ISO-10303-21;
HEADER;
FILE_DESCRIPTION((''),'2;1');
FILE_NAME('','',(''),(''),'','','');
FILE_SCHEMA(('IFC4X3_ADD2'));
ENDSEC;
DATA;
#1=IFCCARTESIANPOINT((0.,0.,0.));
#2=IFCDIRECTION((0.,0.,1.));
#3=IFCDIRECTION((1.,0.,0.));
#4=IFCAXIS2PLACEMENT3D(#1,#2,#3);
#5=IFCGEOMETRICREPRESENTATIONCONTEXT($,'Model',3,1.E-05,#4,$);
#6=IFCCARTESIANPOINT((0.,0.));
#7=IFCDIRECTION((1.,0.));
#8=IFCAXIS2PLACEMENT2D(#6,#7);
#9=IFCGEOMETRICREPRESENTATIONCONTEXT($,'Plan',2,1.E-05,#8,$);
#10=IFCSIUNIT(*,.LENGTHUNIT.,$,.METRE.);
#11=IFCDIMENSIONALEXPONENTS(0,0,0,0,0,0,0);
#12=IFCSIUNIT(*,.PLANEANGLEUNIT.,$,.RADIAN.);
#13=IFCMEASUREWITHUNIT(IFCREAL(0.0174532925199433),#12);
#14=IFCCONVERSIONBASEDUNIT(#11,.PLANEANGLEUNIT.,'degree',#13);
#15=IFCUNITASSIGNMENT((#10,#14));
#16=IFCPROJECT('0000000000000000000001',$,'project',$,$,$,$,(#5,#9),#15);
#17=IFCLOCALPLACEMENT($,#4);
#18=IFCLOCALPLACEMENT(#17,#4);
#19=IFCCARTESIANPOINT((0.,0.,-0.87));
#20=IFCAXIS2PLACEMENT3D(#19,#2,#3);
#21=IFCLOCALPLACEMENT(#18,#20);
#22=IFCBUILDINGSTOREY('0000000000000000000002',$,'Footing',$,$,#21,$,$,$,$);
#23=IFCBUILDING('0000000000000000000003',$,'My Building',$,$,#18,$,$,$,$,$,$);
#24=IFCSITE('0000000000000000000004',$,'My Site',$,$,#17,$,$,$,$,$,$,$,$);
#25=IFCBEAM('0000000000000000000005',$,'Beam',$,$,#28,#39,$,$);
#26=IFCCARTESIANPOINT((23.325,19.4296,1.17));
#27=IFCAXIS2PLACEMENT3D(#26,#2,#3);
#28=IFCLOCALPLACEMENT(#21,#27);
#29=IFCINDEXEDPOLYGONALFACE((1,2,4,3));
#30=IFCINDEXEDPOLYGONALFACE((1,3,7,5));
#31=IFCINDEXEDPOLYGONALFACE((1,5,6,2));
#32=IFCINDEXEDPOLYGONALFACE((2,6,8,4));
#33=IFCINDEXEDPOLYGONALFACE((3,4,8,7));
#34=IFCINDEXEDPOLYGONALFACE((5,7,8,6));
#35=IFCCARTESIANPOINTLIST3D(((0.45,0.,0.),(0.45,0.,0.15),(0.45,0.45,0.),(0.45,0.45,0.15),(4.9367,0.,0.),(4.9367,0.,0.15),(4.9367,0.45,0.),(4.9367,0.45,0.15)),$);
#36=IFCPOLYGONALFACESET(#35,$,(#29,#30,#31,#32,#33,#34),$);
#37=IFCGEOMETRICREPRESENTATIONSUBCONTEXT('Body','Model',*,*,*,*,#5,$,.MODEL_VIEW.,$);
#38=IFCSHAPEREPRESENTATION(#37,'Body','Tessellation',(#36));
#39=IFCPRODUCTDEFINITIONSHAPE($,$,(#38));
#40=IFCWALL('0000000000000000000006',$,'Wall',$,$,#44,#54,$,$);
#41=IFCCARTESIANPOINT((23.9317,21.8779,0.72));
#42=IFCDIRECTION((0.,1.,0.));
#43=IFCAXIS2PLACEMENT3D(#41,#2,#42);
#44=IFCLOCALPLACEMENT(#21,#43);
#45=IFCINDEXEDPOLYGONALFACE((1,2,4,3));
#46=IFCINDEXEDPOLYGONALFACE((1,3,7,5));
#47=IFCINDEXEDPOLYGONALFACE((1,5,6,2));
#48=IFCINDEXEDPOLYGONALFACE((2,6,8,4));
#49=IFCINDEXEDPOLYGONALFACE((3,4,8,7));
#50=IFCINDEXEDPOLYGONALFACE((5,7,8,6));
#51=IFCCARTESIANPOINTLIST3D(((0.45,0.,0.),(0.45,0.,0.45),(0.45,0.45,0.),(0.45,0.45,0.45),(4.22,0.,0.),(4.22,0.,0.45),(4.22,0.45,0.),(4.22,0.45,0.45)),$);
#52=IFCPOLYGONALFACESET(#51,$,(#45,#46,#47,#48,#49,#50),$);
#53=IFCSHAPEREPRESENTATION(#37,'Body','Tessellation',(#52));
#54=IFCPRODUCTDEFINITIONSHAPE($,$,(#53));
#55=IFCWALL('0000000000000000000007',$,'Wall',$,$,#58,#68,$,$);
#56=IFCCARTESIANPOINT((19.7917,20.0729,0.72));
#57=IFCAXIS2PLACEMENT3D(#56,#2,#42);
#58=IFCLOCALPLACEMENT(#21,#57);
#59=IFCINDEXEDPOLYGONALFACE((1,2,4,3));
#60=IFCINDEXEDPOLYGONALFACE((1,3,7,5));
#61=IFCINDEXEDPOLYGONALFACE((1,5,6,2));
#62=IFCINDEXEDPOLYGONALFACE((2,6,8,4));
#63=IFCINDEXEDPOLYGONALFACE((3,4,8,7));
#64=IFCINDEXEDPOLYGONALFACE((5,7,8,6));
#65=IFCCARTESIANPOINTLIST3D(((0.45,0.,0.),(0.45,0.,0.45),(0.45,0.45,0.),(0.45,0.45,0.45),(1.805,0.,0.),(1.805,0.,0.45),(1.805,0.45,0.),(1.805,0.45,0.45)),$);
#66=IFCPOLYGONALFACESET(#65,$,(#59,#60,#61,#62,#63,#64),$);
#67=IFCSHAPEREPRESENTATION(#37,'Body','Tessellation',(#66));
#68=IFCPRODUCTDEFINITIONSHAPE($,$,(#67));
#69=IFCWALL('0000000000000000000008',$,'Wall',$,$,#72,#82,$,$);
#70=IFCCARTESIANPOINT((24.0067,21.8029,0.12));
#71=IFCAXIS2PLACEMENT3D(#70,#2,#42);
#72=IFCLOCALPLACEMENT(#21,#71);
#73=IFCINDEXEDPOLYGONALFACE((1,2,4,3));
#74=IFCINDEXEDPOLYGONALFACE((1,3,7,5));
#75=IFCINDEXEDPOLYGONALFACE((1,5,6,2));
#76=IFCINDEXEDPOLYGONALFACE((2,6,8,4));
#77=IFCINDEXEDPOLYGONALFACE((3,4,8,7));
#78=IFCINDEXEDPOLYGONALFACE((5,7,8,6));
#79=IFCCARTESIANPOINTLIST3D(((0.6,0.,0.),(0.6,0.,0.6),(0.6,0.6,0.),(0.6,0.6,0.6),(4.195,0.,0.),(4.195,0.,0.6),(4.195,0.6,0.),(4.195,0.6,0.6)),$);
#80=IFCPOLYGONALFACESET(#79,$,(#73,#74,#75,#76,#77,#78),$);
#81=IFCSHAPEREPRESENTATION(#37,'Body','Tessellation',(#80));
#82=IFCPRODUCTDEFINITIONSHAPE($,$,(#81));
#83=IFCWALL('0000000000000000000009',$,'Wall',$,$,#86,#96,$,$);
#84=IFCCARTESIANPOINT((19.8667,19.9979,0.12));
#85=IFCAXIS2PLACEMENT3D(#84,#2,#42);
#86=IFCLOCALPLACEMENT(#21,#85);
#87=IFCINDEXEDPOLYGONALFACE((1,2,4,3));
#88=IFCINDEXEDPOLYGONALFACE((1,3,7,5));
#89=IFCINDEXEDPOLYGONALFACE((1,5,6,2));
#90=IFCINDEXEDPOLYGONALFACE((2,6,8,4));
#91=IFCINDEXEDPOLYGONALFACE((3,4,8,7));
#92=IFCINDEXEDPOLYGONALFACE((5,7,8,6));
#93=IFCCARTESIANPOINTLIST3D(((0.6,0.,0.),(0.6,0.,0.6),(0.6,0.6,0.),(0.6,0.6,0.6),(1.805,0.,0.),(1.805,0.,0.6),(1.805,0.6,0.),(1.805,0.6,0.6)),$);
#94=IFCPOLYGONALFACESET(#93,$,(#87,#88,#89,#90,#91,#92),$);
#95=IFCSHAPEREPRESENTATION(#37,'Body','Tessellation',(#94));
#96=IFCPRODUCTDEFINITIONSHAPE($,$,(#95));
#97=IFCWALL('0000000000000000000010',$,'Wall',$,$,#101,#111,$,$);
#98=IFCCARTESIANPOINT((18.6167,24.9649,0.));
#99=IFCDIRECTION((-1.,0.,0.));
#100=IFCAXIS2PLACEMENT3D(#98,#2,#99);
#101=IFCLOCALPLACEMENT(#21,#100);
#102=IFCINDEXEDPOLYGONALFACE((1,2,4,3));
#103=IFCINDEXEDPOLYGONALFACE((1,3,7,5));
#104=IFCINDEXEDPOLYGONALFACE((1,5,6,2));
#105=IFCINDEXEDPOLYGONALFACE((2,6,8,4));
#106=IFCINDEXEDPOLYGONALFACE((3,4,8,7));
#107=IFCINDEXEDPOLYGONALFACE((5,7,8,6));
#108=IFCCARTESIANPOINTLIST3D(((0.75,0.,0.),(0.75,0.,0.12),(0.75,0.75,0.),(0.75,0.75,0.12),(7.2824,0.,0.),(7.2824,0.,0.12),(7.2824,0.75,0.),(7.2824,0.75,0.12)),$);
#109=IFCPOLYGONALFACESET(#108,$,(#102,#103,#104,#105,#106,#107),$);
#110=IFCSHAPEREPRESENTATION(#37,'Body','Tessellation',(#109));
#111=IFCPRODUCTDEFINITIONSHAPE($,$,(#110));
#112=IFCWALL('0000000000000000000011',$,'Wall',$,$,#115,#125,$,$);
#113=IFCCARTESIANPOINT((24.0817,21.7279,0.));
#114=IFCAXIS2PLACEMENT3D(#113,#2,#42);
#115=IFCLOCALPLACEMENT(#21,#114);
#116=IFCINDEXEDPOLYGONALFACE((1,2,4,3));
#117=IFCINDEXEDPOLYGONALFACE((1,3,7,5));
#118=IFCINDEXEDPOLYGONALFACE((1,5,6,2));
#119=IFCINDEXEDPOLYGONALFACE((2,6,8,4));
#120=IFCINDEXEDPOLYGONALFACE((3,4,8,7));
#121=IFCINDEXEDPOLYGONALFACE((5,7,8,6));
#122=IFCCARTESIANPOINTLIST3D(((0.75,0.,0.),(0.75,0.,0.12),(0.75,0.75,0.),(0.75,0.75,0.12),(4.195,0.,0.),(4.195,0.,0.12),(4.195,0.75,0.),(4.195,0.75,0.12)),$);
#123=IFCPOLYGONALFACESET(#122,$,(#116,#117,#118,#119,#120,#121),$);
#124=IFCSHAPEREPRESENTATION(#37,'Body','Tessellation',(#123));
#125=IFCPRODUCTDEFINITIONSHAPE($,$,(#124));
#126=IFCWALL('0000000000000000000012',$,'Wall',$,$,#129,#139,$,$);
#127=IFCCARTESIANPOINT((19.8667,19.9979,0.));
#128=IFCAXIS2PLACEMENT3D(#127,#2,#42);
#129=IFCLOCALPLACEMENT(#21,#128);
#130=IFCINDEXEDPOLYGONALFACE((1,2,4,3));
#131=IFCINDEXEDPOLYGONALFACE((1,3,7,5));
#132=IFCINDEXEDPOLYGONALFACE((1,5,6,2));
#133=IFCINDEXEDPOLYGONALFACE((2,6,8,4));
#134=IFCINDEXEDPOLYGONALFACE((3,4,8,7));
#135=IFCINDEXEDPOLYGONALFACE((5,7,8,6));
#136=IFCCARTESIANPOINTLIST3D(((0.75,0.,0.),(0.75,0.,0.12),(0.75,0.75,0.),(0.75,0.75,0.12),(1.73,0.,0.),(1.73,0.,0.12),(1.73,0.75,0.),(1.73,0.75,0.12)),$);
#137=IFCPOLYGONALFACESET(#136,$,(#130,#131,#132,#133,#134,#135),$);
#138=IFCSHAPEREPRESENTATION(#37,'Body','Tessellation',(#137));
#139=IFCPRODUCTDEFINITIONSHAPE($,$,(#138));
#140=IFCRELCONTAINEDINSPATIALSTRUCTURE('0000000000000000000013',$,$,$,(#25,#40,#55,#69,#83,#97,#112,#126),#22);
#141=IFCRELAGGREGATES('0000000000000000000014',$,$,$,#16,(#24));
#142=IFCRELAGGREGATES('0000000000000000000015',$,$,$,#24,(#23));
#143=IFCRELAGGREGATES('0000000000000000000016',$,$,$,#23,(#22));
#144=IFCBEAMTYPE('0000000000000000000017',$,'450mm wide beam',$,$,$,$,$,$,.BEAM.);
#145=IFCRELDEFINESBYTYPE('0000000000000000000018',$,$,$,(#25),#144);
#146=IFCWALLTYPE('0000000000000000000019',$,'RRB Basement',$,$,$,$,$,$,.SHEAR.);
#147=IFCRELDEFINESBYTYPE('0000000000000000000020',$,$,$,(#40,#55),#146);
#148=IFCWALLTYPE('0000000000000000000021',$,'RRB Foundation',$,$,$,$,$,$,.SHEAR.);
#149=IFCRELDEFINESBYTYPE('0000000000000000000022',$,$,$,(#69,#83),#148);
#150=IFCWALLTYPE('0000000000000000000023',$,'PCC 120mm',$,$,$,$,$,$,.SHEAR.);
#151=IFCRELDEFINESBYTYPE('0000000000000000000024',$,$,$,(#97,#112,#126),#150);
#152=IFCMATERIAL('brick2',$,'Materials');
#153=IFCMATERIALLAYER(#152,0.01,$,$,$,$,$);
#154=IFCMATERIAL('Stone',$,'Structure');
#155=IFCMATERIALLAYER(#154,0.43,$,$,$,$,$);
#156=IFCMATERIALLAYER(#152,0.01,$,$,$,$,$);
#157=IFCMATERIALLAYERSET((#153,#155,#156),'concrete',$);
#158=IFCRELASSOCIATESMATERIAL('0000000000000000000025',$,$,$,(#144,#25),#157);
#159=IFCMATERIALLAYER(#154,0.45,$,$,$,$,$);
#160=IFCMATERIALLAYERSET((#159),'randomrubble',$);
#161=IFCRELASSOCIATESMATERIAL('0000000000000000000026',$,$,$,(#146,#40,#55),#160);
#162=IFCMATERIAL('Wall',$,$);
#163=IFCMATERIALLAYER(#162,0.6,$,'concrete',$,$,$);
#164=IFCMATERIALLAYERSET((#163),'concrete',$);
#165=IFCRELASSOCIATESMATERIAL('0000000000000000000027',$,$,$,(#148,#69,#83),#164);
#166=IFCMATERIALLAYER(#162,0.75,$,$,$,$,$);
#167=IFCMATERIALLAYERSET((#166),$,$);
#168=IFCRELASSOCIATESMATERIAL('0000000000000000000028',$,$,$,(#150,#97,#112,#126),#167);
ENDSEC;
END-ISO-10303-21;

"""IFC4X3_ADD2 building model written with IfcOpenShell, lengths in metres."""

from ifc_helpers import new_model, entity, si_unit, converted_unit, frame, origin_with_axes, origin_2d_with_axis, place, context, subcontext, project, spatial, line, indexed_curve, outline, extrude, material, layer, layer_set, layer_usage, type_object, element, save


model = new_model("IFC4X3_ADD2")

# Units and contexts
model_context = context("Model", 3, precision=1e-05, world=origin_with_axes())
plan_context = context("Plan", 2, precision=1e-05, world=origin_2d_with_axis())
body_context = subcontext(model_context, "Body", "Model", "MODEL_VIEW")
ifc_project = project(units=[si_unit("LENGTHUNIT", "METRE"), converted_unit("PLANEANGLEUNIT", "degree", entity("IfcReal", 0.0174532925199433), si_unit("PLANEANGLEUNIT", "RADIAN"), dimensions=[0, 0, 0, 0, 0, 0, 0])], contexts=[model_context, plan_context])

# Site, building, storey
site_placement = place(None, origin_with_axes())
site = spatial("IfcSite", under=ifc_project, at=site_placement, Name="My Site")
building_placement = place(site_placement, origin_with_axes())
building = spatial("IfcBuilding", under=site, at=building_placement, Name="My Building")
storey_placement = place(building_placement, frame((0.0, 0.0, -0.87), z_axis=(0.0, 0.0, 1.0), x_axis=(1.0, 0.0, 0.0)))
storey = spatial("IfcBuildingStorey", under=building, at=storey_placement, Name="Footing")

# Beam
ifc_material_1 = material(Name="brick2", Category="Materials")
ifc_layer_1 = layer(ifc_material_1, 0.01)
ifc_material_2 = material(Name="Stone", Category="Structure")
ifc_layer_2 = layer(ifc_material_2, 0.43)
ifc_layer_3 = layer(ifc_material_1, 0.01)
ifc_layer_set_1 = layer_set([ifc_layer_1, ifc_layer_2, ifc_layer_3], Name="concrete")
beam_type_1 = type_object("IfcBeamType", Name="450mm wide beam", PredefinedType="BEAM", material=ifc_layer_set_1)
ifc_layer_usage_1 = layer_usage(ifc_layer_set_1, "AXIS2", "POSITIVE", 0.0)
beam_1_placement = place(storey_placement, frame((23.325, 19.4296, 1.17), z_axis=(0.0, 0.0, 1.0), x_axis=(1.0, 0.0, 0.0)))
element("IfcBeam", 1, at=beam_1_placement, inside=storey, type_object=beam_type_1, material=ifc_layer_usage_1, Name="Beam", context=body_context, shape_type="SweptSolid", body=[
    extrude(outline(indexed_curve([(0.45, 0.0), (0.45, 0.45), (4.9367, 0.45), (4.9367, 0.0)], segments=[line(1, 2, 3, 4, 1)])), origin_with_axes(), (0.0, 0.0, 1.0), 0.15),
])

# Walls
ifc_layer_4 = layer(ifc_material_2, 0.45)
ifc_layer_set_2 = layer_set([ifc_layer_4], Name="randomrubble")
ifc_layer_usage_2 = layer_usage(ifc_layer_set_2, "AXIS2", "POSITIVE", 0.0)
wall_type_1 = type_object("IfcWallType", Name="RRB Basement", PredefinedType="SHEAR", material=ifc_layer_set_2)
wall_1_placement = place(storey_placement, frame((23.9317, 21.8779, 0.72), z_axis=(0.0, 0.0, 1.0), x_axis=(0.0, 1.0, 0.0)))
element("IfcWall", 2, at=wall_1_placement, inside=storey, type_object=wall_type_1, material=ifc_layer_usage_2, Name="Wall", context=body_context, shape_type="SweptSolid", body=[
    extrude(outline(indexed_curve([(0.45, 0.0), (0.45, 0.45), (4.22, 0.45), (4.22, 0.0)], segments=[line(1, 2, 3, 4, 1)])), origin_with_axes(), (0.0, 0.0, 1.0), 0.45),
])
ifc_layer_usage_3 = layer_usage(ifc_layer_set_2, "AXIS2", "POSITIVE", 0.0)
wall_2_placement = place(storey_placement, frame((19.7917, 20.0729, 0.72), z_axis=(0.0, 0.0, 1.0), x_axis=(0.0, 1.0, 0.0)))
element("IfcWall", 3, at=wall_2_placement, inside=storey, type_object=wall_type_1, material=ifc_layer_usage_3, Name="Wall", context=body_context, shape_type="SweptSolid", body=[
    extrude(outline(indexed_curve([(0.45, 0.0), (0.45, 0.45), (1.805, 0.45), (1.805, 0.0)], segments=[line(1, 2, 3, 4, 1)])), origin_with_axes(), (0.0, 0.0, 1.0), 0.45),
])
ifc_material_3 = material(Name="Wall")
ifc_layer_5 = layer(ifc_material_3, 0.6, Name="concrete")
ifc_layer_set_3 = layer_set([ifc_layer_5], Name="concrete")
ifc_layer_usage_4 = layer_usage(ifc_layer_set_3, "AXIS2", "POSITIVE", 0.0)
wall_type_2 = type_object("IfcWallType", Name="RRB Foundation", PredefinedType="SHEAR", material=ifc_layer_set_3)
wall_3_placement = place(storey_placement, frame((24.0067, 21.8029, 0.12), z_axis=(0.0, 0.0, 1.0), x_axis=(0.0, 1.0, 0.0)))
element("IfcWall", 4, at=wall_3_placement, inside=storey, type_object=wall_type_2, material=ifc_layer_usage_4, Name="Wall", context=body_context, shape_type="SweptSolid", body=[
    extrude(outline(indexed_curve([(0.6, 0.0), (0.6, 0.6), (4.195, 0.6), (4.195, 0.0)], segments=[line(1, 2, 3, 4, 1)])), origin_with_axes(), (0.0, 0.0, 1.0), 0.6),
])
ifc_layer_usage_5 = layer_usage(ifc_layer_set_3, "AXIS2", "POSITIVE", 0.0)
wall_4_placement = place(storey_placement, frame((19.8667, 19.9979, 0.12), z_axis=(0.0, 0.0, 1.0), x_axis=(0.0, 1.0, 0.0)))
element("IfcWall", 5, at=wall_4_placement, inside=storey, type_object=wall_type_2, material=ifc_layer_usage_5, Name="Wall", context=body_context, shape_type="SweptSolid", body=[
    extrude(outline(indexed_curve([(0.6, 0.0), (0.6, 0.6), (1.805, 0.6), (1.805, 0.0)], segments=[line(1, 2, 3, 4, 1)])), origin_with_axes(), (0.0, 0.0, 1.0), 0.6),
])
ifc_layer_6 = layer(ifc_material_3, 0.75)
ifc_layer_set_4 = layer_set([ifc_layer_6])
ifc_layer_usage_6 = layer_usage(ifc_layer_set_4, "AXIS2", "POSITIVE", 0.0)
wall_type_3 = type_object("IfcWallType", Name="PCC 120mm", PredefinedType="SHEAR", material=ifc_layer_set_4)
wall_5_placement = place(storey_placement, frame((18.6167, 24.9649, 0.0), z_axis=(0.0, 0.0, 1.0), x_axis=(-1.0, 0.0, 0.0)))
element("IfcWall", 6, at=wall_5_placement, inside=storey, type_object=wall_type_3, material=ifc_layer_usage_6, Name="Wall", context=body_context, shape_type="SweptSolid", body=[
    extrude(outline(indexed_curve([(0.75, 0.0), (0.75, 0.75), (7.2824, 0.75), (7.2824, 0.0)], segments=[line(1, 2, 3, 4, 1)])), origin_with_axes(), (0.0, 0.0, 1.0), 0.12),
])
ifc_layer_usage_7 = layer_usage(ifc_layer_set_4, "AXIS2", "POSITIVE", 0.0)
wall_6_placement = place(storey_placement, frame((24.0817, 21.7279, 0.0), z_axis=(0.0, 0.0, 1.0), x_axis=(0.0, 1.0, 0.0)))
element("IfcWall", 7, at=wall_6_placement, inside=storey, type_object=wall_type_3, material=ifc_layer_usage_7, Name="Wall", context=body_context, shape_type="SweptSolid", body=[
    extrude(outline(indexed_curve([(0.75, 0.0), (0.75, 0.75), (4.195, 0.75), (4.195, 0.0)], segments=[line(1, 2, 3, 4, 1)])), origin_with_axes(), (0.0, 0.0, 1.0), 0.12),
])
ifc_layer_usage_8 = layer_usage(ifc_layer_set_4, "AXIS2", "POSITIVE", 0.0)
wall_7_placement = place(storey_placement, frame((19.8667, 19.9979, 0.0), z_axis=(0.0, 0.0, 1.0), x_axis=(0.0, 1.0, 0.0)))
element("IfcWall", 8, at=wall_7_placement, inside=storey, type_object=wall_type_3, material=ifc_layer_usage_8, Name="Wall", context=body_context, shape_type="SweptSolid", body=[
    extrude(outline(indexed_curve([(0.75, 0.0), (0.75, 0.75), (1.73, 0.75), (1.73, 0.0)], segments=[line(1, 2, 3, 4, 1)])), origin_with_axes(), (0.0, 0.0, 1.0), 0.12),
])

save(model, "model.ifc")
